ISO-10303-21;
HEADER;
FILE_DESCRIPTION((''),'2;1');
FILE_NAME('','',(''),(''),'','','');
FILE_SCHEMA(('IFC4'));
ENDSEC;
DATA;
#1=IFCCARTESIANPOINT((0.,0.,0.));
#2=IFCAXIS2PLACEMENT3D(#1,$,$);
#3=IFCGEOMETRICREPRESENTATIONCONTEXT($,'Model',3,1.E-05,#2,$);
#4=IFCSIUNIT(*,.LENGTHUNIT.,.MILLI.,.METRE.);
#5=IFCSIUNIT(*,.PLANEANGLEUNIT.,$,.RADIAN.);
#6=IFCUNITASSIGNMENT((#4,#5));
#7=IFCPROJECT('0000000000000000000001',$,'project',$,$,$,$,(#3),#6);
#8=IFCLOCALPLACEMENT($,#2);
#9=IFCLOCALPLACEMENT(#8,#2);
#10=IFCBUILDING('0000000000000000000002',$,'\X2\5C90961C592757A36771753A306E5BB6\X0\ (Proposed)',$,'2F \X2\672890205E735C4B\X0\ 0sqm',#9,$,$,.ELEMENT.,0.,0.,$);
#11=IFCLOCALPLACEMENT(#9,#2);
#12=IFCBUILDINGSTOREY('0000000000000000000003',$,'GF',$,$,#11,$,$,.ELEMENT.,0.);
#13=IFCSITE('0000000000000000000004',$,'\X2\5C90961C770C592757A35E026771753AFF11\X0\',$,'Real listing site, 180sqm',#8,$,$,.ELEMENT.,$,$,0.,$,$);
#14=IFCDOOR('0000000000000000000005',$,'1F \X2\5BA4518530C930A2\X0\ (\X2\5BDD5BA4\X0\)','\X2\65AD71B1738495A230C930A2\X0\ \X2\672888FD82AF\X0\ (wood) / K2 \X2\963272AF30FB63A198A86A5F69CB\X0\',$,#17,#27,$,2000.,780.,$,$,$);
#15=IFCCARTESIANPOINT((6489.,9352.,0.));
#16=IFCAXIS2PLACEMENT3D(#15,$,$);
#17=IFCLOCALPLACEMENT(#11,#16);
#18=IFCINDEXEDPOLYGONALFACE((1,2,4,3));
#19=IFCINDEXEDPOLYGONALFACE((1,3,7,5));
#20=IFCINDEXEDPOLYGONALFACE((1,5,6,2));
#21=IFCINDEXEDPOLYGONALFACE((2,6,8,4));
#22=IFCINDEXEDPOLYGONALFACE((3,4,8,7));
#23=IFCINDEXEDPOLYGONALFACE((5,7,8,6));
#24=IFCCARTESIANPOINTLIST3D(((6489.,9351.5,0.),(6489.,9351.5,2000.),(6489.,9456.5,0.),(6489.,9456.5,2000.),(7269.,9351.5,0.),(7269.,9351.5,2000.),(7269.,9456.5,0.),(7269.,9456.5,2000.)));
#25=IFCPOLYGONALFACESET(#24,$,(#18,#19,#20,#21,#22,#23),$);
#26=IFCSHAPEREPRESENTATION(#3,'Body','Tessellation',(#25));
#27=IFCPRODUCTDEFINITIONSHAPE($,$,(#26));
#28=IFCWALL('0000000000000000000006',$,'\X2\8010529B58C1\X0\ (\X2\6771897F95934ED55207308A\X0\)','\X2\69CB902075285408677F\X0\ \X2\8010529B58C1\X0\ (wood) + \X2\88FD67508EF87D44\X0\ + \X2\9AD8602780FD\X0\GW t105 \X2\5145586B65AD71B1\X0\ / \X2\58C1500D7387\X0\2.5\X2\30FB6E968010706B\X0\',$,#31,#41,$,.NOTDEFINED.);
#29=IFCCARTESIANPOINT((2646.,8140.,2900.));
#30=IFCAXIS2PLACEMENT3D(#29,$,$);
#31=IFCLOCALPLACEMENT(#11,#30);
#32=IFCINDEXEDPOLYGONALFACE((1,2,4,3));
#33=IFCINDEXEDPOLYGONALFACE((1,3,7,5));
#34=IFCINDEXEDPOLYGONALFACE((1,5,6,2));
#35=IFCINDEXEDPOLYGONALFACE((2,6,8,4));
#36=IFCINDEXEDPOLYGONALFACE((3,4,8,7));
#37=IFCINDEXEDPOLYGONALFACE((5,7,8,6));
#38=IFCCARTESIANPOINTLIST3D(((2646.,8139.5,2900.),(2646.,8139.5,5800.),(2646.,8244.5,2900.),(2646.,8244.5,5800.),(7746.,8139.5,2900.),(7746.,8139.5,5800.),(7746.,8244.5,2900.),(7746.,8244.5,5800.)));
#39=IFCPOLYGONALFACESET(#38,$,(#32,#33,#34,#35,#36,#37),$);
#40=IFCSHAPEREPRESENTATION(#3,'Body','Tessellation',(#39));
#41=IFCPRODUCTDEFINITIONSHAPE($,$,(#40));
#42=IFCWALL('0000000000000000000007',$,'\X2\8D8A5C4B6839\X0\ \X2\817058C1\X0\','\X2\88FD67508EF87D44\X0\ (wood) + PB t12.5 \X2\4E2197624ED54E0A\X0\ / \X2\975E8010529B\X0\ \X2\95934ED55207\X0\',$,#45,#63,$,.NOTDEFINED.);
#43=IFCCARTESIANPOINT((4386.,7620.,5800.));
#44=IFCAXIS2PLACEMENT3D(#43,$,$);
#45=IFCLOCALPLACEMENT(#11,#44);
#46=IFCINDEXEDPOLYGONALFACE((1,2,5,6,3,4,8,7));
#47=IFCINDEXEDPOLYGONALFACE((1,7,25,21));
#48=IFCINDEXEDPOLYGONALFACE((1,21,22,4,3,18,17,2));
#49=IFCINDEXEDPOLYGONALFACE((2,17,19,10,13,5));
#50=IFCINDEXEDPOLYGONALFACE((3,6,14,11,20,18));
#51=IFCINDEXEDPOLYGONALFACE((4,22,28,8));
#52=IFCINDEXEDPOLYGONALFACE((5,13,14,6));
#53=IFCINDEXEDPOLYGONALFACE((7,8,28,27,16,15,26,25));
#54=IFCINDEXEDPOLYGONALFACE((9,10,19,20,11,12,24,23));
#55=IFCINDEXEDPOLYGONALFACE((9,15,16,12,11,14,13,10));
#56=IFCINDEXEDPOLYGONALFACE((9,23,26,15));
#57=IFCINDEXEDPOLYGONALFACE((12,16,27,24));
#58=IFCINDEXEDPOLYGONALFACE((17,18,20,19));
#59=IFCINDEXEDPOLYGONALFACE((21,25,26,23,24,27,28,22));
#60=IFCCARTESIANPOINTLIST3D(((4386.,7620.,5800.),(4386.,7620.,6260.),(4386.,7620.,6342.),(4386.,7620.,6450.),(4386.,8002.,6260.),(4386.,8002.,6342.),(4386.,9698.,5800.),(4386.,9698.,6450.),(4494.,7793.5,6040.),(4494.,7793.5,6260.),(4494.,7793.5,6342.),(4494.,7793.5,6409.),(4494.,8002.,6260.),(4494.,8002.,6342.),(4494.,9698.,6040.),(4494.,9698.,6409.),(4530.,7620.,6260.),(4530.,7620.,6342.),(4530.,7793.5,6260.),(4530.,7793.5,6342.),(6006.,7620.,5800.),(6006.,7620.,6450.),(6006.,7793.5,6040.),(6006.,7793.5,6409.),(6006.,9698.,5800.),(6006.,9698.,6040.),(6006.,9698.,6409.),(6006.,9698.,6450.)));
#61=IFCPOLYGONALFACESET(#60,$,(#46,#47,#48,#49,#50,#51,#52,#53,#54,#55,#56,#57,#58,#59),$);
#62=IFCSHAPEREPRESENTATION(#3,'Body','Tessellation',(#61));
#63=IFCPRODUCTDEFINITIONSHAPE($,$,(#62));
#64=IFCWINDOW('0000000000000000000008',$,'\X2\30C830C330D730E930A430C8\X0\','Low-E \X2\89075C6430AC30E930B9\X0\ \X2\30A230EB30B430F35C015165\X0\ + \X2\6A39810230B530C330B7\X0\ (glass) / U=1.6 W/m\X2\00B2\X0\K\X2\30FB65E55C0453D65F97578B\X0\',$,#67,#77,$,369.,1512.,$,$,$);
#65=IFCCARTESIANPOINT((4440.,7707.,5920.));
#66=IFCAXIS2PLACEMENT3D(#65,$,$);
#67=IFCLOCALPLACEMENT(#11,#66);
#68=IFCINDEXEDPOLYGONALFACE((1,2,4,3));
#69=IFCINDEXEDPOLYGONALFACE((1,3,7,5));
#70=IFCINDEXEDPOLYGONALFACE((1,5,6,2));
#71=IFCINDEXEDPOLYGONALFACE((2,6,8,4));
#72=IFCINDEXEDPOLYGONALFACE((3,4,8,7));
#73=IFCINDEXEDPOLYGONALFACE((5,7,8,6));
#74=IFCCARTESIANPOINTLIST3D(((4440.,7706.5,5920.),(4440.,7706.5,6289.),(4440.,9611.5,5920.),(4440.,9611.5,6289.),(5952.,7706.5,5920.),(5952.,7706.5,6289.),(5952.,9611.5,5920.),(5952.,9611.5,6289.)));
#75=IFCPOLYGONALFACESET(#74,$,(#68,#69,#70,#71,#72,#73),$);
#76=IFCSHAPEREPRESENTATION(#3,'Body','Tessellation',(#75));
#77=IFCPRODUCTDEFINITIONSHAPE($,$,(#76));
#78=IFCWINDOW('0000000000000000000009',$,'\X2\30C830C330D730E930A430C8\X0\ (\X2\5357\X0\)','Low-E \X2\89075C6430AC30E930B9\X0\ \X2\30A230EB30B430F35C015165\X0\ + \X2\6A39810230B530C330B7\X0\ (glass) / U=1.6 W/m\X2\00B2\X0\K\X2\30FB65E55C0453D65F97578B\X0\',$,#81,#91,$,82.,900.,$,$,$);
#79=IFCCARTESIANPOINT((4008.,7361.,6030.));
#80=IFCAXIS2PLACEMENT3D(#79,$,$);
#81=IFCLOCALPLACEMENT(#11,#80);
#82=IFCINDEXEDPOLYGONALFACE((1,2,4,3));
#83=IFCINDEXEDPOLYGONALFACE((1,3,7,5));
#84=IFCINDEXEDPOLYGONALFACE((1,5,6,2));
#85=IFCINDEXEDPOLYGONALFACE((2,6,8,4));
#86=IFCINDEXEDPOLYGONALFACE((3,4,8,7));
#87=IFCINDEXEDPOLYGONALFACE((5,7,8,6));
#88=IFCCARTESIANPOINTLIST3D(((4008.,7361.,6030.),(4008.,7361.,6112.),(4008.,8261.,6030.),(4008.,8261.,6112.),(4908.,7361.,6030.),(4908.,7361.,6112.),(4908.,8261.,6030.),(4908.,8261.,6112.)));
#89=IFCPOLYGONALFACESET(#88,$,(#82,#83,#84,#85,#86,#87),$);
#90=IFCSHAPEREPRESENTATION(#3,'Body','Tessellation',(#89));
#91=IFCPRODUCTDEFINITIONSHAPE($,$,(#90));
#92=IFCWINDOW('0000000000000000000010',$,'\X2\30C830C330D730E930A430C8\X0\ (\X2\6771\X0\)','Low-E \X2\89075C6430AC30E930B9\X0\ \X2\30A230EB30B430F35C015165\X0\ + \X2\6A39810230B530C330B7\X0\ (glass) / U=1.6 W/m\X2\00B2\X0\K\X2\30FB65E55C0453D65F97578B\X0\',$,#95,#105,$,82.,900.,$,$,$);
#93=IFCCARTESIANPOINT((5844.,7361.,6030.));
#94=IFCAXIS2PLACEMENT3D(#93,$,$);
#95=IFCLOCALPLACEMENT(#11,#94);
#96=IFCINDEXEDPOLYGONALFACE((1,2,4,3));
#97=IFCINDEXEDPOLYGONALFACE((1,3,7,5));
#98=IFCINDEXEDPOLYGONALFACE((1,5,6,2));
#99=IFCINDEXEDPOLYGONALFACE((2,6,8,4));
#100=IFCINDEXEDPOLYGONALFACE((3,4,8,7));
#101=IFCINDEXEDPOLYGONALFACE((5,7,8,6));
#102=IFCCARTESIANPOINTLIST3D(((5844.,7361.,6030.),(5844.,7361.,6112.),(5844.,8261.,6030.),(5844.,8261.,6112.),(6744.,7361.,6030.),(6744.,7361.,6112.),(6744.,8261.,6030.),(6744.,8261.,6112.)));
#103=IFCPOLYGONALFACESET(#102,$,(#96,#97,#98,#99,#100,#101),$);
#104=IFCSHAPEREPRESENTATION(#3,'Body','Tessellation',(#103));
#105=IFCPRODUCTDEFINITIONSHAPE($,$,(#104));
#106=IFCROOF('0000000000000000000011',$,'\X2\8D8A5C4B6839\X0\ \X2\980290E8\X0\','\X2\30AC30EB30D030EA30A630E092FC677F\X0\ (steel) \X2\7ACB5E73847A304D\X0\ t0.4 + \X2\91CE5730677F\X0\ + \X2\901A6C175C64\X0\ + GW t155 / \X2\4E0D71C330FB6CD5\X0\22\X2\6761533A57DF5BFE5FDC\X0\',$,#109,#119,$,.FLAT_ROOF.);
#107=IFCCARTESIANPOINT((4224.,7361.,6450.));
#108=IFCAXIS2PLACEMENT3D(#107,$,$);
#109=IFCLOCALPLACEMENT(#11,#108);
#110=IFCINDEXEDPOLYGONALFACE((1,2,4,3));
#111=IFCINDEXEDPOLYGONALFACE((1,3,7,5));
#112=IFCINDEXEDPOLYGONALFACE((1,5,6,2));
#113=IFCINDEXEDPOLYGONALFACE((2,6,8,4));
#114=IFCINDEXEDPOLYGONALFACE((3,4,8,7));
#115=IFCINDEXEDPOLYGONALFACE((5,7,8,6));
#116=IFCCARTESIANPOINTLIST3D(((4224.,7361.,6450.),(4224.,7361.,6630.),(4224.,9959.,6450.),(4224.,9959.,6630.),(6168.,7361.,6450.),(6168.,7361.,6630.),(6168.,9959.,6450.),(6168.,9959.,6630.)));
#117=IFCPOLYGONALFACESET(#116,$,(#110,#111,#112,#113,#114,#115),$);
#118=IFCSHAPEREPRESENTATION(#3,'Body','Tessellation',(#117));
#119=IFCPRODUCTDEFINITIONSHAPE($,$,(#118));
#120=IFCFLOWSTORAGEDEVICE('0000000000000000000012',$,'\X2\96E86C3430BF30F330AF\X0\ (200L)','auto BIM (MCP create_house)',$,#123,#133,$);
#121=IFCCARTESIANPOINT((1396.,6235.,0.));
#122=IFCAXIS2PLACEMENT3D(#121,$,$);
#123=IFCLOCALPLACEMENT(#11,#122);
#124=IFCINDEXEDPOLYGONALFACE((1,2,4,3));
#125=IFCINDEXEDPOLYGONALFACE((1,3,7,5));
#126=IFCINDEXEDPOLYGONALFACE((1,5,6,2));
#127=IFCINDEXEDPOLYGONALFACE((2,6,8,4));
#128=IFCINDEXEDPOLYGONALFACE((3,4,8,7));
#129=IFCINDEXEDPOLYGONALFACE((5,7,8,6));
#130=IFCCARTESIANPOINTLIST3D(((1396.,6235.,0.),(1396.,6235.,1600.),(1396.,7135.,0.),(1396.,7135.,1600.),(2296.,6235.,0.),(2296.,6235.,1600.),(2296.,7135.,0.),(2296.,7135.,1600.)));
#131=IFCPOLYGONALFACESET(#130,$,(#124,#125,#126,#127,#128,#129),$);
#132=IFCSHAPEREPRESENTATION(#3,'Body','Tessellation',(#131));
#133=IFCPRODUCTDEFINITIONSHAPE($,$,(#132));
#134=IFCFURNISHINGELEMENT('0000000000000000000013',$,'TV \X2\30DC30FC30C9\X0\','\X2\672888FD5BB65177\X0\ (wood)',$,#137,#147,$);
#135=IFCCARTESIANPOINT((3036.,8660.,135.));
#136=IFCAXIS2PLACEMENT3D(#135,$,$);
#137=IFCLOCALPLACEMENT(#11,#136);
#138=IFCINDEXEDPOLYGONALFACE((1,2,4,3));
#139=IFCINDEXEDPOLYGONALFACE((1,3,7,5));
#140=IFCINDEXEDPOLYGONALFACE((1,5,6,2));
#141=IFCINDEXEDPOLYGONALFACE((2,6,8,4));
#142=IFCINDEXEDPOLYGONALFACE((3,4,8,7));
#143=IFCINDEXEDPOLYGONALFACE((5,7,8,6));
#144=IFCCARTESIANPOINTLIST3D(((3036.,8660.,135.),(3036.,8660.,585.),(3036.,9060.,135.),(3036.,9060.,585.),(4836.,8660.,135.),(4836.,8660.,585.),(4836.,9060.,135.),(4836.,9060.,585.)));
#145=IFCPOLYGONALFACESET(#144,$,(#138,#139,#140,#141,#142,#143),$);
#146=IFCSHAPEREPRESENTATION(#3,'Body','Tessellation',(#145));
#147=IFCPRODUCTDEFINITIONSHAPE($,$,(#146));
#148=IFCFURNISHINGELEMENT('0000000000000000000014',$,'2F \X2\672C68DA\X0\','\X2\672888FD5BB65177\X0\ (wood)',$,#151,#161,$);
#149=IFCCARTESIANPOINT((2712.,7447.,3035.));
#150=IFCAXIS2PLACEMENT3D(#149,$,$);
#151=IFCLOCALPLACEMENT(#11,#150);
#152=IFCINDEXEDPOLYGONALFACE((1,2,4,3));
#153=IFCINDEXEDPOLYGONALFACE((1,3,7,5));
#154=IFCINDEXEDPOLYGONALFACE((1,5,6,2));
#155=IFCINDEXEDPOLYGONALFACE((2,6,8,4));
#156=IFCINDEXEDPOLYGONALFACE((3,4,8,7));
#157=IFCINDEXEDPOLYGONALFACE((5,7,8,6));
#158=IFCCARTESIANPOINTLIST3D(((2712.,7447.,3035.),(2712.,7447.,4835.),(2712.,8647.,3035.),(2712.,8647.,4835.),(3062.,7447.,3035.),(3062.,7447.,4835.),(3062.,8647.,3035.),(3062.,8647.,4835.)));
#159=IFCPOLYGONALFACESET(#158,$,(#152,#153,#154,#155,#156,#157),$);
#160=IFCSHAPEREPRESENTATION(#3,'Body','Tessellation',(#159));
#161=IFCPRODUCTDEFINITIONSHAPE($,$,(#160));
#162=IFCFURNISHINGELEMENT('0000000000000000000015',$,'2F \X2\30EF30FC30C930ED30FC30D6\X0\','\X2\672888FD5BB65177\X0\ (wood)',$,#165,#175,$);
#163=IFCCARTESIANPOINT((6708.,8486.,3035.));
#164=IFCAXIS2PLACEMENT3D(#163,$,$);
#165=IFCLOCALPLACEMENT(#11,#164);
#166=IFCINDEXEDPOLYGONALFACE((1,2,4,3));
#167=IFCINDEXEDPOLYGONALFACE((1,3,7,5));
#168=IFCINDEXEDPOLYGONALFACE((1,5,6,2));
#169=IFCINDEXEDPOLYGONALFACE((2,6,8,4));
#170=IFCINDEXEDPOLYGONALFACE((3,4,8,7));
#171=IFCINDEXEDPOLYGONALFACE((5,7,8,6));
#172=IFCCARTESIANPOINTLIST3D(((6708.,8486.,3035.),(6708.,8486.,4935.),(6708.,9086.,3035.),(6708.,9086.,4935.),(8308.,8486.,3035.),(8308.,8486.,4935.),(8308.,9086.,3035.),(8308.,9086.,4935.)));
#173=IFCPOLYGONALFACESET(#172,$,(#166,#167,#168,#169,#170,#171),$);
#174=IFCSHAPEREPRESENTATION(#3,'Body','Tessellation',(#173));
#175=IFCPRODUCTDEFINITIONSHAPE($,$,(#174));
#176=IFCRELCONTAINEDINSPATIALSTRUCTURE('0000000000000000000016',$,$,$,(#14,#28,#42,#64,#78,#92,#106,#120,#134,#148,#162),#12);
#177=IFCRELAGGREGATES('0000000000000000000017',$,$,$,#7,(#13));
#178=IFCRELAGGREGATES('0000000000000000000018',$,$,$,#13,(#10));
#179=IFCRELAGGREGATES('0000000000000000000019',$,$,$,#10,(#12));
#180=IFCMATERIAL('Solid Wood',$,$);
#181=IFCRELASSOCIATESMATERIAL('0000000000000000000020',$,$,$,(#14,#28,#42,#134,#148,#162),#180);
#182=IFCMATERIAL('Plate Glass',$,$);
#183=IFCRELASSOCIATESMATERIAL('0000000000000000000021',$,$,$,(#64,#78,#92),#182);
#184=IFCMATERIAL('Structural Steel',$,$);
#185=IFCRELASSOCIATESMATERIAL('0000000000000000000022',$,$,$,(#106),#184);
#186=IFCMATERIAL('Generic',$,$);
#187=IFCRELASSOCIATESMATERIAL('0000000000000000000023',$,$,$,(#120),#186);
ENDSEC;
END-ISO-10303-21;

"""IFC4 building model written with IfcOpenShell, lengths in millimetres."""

from ifc_helpers import new_model, si_unit, frame, frame_2d, origin, place, context, project, spatial, rectangle, extrude, material, element, fill, save


model = new_model("IFC4")

# Units and contexts
model_context = context("Model", 3, precision=1e-05, world=origin())
ifc_project = project(units=[si_unit("LENGTHUNIT", "METRE", prefix="MILLI"), si_unit("PLANEANGLEUNIT", "RADIAN")], contexts=[model_context])

# Site, building, storey
site_placement = place(None, origin())
site = spatial("IfcSite", under=ifc_project, at=site_placement, Name="岐阜県大垣市東町１", ObjectType="Real listing site, 180sqm", CompositionType="ELEMENT", RefElevation=0.0)
building_placement = place(site_placement, origin())
building = spatial("IfcBuilding", under=site, at=building_placement, Name="岐阜大垣東町の家 (Proposed)", ObjectType="2F 木造平屋 0sqm", CompositionType="ELEMENT", ElevationOfRefHeight=0.0, ElevationOfTerrain=0.0)
storey_placement = place(building_placement, origin())
storey = spatial("IfcBuildingStorey", under=building, at=storey_placement, Name="GF", CompositionType="ELEMENT", Elevation=0.0)

# Shared definitions
ifc_material_1 = material(Name="Solid Wood")

# Door
door_placement = place(storey_placement, frame((6489.0, 9352.0, 0.0)))
element("IfcDoor", 1, at=door_placement, inside=storey, material=ifc_material_1, Name="1F 室内ドア (寝室)", Description="断熱玄関ドア 木製芯 (wood) / K2 防犯・採風機構", OverallHeight=2000.0, OverallWidth=780.0, context=model_context, shape_type="SweptSolid", body=[
    extrude(rectangle(XDim=780.0, YDim=105.0, at=frame_2d((390.0, 52.0))), frame((6489.0, 9352.0, 0.0)), (0.0, 0.0, 1.0), 2000.0),
])

# Wall
wall_1_placement = place(storey_placement, frame((2646.0, 8140.0, 2900.0)))
element("IfcWall", 2, at=wall_1_placement, inside=storey, material=ifc_material_1, Name="耐力壁 (東西間仕切り)", Description="構造用合板 耐力壁 (wood) + 製材軸組 + 高性能GW t105 充填断熱 / 壁倍率2.5・準耐火", PredefinedType="NOTDEFINED", context=model_context, shape_type="SweptSolid", body=[
    extrude(rectangle(XDim=5100.0, YDim=105.0, at=frame_2d((2550.0, 52.0))), frame((2646.0, 8140.0, 2900.0)), (0.0, 0.0, 1.0), 2900.0),
])

# Wall, openings, windows
wall_2_placement = place(storey_placement, frame((4386.0, 7620.0, 5800.0)))
wall_2 = element("IfcWall", 3, at=wall_2_placement, inside=storey, material=ifc_material_1, Name="越屋根 腰壁", Description="製材軸組 (wood) + PB t12.5 両面仕上 / 非耐力 間仕切", PredefinedType="NOTDEFINED", context=model_context, shape_type="SweptSolid", body=[
    extrude(rectangle(XDim=1620.0, YDim=2078.0, at=frame_2d((810.0, 1039.0))), frame((4386.0, 7620.0, 5800.0)), (0.0, 0.0, 1.0), 650.0),
])
opening_1_placement = place(storey_placement, frame((4440.0, 7707.0, 5920.0)))
opening_1 = element("IfcOpeningElement", 4, at=opening_1_placement, cuts=wall_2, PredefinedType="NOTDEFINED", context=model_context, shape_type="SweptSolid", body=[
    extrude(rectangle(XDim=1512.0, YDim=1905.0, at=frame_2d((756.0, 952.0))), frame((4440.0, 7707.0, 5920.0)), (0.0, 0.0, 1.0), 369.0),
])
opening_2_placement = place(storey_placement, frame((4008.0, 7361.0, 6030.0)))
opening_2 = element("IfcOpeningElement", 5, at=opening_2_placement, cuts=wall_2, PredefinedType="NOTDEFINED", context=model_context, shape_type="SweptSolid", body=[
    extrude(rectangle(XDim=900.0, YDim=900.0, at=frame_2d((450.0, 450.0))), frame((4008.0, 7361.0, 6030.0)), (0.0, 0.0, 1.0), 82.0),
])
opening_3_placement = place(storey_placement, frame((5844.0, 7361.0, 6030.0)))
opening_3 = element("IfcOpeningElement", 6, at=opening_3_placement, cuts=wall_2, PredefinedType="NOTDEFINED", context=model_context, shape_type="SweptSolid", body=[
    extrude(rectangle(XDim=900.0, YDim=900.0, at=frame_2d((450.0, 450.0))), frame((5844.0, 7361.0, 6030.0)), (0.0, 0.0, 1.0), 82.0),
])
ifc_material_2 = material(Name="Plate Glass")
window_1_placement = place(storey_placement, frame((4440.0, 7707.0, 5920.0)))
window_1 = element("IfcWindow", 7, at=window_1_placement, inside=storey, material=ifc_material_2, Name="トップライト", Description="Low-E 複層ガラス アルゴン封入 + 樹脂サッシ (glass) / U=1.6 W/m²K・日射取得型", OverallHeight=369.0, OverallWidth=1512.0, context=model_context, shape_type="SweptSolid", body=[
    extrude(rectangle(XDim=1512.0, YDim=1905.0, at=frame_2d((756.0, 952.0))), frame((4440.0, 7707.0, 5920.0)), (0.0, 0.0, 1.0), 369.0),
])
fill(opening_1, window_1)
window_2_placement = place(storey_placement, frame((4008.0, 7361.0, 6030.0)))
window_2 = element("IfcWindow", 8, at=window_2_placement, inside=storey, material=ifc_material_2, Name="トップライト (南)", Description="Low-E 複層ガラス アルゴン封入 + 樹脂サッシ (glass) / U=1.6 W/m²K・日射取得型", OverallHeight=82.0, OverallWidth=900.0, context=model_context, shape_type="SweptSolid", body=[
    extrude(rectangle(XDim=900.0, YDim=900.0, at=frame_2d((450.0, 450.0))), frame((4008.0, 7361.0, 6030.0)), (0.0, 0.0, 1.0), 82.0),
])
fill(opening_2, window_2)
window_3_placement = place(storey_placement, frame((5844.0, 7361.0, 6030.0)))
window_3 = element("IfcWindow", 9, at=window_3_placement, inside=storey, material=ifc_material_2, Name="トップライト (東)", Description="Low-E 複層ガラス アルゴン封入 + 樹脂サッシ (glass) / U=1.6 W/m²K・日射取得型", OverallHeight=82.0, OverallWidth=900.0, context=model_context, shape_type="SweptSolid", body=[
    extrude(rectangle(XDim=900.0, YDim=900.0, at=frame_2d((450.0, 450.0))), frame((5844.0, 7361.0, 6030.0)), (0.0, 0.0, 1.0), 82.0),
])
fill(opening_3, window_3)

# Roof
ifc_material_3 = material(Name="Structural Steel")
roof_placement = place(storey_placement, frame((4224.0, 7361.0, 6450.0)))
element("IfcRoof", 10, at=roof_placement, inside=storey, material=ifc_material_3, Name="越屋根 頂部", Description="ガルバリウム鋼板 (steel) 立平葺き t0.4 + 野地板 + 通気層 + GW t155 / 不燃・法22条区域対応", PredefinedType="FLAT_ROOF", context=model_context, shape_type="SweptSolid", body=[
    extrude(rectangle(XDim=1944.0, YDim=2598.0, at=frame_2d((972.0, 1299.0))), frame((4224.0, 7361.0, 6450.0)), (0.0, 0.0, 1.0), 180.0),
])

# Flow storage device
ifc_material_4 = material(Name="Generic")
flow_storage_device_placement = place(storey_placement, frame((1396.0, 6235.0, 0.0)))
element("IfcFlowStorageDevice", 11, at=flow_storage_device_placement, inside=storey, material=ifc_material_4, Name="雨水タンク (200L)", Description="auto BIM (MCP create_house)", context=model_context, shape_type="SweptSolid", body=[
    extrude(rectangle(XDim=900.0, YDim=900.0, at=frame_2d((450.0, 450.0))), frame((1396.0, 6235.0, 0.0)), (0.0, 0.0, 1.0), 1600.0),
])

# Furnishing elements
furnishing_1_placement = place(storey_placement, frame((3036.0, 8660.0, 135.0)))
element("IfcFurnishingElement", 12, at=furnishing_1_placement, inside=storey, material=ifc_material_1, Name="TV ボード", Description="木製家具 (wood)", context=model_context, shape_type="SweptSolid", body=[
    extrude(rectangle(XDim=1800.0, YDim=400.0, at=frame_2d((900.0, 200.0))), frame((3036.0, 8660.0, 135.0)), (0.0, 0.0, 1.0), 450.0),
])
furnishing_2_placement = place(storey_placement, frame((2712.0, 7447.0, 3035.0)))
element("IfcFurnishingElement", 13, at=furnishing_2_placement, inside=storey, material=ifc_material_1, Name="2F 本棚", Description="木製家具 (wood)", context=model_context, shape_type="SweptSolid", body=[
    extrude(rectangle(XDim=350.0, YDim=1200.0, at=frame_2d((175.0, 600.0))), frame((2712.0, 7447.0, 3035.0)), (0.0, 0.0, 1.0), 1800.0),
])
furnishing_3_placement = place(storey_placement, frame((6708.0, 8486.0, 3035.0)))
element("IfcFurnishingElement", 14, at=furnishing_3_placement, inside=storey, material=ifc_material_1, Name="2F ワードローブ", Description="木製家具 (wood)", context=model_context, shape_type="SweptSolid", body=[
    extrude(rectangle(XDim=1600.0, YDim=600.0, at=frame_2d((800.0, 300.0))), frame((6708.0, 8486.0, 3035.0)), (0.0, 0.0, 1.0), 1900.0),
])

save(model, "model.ifc")
